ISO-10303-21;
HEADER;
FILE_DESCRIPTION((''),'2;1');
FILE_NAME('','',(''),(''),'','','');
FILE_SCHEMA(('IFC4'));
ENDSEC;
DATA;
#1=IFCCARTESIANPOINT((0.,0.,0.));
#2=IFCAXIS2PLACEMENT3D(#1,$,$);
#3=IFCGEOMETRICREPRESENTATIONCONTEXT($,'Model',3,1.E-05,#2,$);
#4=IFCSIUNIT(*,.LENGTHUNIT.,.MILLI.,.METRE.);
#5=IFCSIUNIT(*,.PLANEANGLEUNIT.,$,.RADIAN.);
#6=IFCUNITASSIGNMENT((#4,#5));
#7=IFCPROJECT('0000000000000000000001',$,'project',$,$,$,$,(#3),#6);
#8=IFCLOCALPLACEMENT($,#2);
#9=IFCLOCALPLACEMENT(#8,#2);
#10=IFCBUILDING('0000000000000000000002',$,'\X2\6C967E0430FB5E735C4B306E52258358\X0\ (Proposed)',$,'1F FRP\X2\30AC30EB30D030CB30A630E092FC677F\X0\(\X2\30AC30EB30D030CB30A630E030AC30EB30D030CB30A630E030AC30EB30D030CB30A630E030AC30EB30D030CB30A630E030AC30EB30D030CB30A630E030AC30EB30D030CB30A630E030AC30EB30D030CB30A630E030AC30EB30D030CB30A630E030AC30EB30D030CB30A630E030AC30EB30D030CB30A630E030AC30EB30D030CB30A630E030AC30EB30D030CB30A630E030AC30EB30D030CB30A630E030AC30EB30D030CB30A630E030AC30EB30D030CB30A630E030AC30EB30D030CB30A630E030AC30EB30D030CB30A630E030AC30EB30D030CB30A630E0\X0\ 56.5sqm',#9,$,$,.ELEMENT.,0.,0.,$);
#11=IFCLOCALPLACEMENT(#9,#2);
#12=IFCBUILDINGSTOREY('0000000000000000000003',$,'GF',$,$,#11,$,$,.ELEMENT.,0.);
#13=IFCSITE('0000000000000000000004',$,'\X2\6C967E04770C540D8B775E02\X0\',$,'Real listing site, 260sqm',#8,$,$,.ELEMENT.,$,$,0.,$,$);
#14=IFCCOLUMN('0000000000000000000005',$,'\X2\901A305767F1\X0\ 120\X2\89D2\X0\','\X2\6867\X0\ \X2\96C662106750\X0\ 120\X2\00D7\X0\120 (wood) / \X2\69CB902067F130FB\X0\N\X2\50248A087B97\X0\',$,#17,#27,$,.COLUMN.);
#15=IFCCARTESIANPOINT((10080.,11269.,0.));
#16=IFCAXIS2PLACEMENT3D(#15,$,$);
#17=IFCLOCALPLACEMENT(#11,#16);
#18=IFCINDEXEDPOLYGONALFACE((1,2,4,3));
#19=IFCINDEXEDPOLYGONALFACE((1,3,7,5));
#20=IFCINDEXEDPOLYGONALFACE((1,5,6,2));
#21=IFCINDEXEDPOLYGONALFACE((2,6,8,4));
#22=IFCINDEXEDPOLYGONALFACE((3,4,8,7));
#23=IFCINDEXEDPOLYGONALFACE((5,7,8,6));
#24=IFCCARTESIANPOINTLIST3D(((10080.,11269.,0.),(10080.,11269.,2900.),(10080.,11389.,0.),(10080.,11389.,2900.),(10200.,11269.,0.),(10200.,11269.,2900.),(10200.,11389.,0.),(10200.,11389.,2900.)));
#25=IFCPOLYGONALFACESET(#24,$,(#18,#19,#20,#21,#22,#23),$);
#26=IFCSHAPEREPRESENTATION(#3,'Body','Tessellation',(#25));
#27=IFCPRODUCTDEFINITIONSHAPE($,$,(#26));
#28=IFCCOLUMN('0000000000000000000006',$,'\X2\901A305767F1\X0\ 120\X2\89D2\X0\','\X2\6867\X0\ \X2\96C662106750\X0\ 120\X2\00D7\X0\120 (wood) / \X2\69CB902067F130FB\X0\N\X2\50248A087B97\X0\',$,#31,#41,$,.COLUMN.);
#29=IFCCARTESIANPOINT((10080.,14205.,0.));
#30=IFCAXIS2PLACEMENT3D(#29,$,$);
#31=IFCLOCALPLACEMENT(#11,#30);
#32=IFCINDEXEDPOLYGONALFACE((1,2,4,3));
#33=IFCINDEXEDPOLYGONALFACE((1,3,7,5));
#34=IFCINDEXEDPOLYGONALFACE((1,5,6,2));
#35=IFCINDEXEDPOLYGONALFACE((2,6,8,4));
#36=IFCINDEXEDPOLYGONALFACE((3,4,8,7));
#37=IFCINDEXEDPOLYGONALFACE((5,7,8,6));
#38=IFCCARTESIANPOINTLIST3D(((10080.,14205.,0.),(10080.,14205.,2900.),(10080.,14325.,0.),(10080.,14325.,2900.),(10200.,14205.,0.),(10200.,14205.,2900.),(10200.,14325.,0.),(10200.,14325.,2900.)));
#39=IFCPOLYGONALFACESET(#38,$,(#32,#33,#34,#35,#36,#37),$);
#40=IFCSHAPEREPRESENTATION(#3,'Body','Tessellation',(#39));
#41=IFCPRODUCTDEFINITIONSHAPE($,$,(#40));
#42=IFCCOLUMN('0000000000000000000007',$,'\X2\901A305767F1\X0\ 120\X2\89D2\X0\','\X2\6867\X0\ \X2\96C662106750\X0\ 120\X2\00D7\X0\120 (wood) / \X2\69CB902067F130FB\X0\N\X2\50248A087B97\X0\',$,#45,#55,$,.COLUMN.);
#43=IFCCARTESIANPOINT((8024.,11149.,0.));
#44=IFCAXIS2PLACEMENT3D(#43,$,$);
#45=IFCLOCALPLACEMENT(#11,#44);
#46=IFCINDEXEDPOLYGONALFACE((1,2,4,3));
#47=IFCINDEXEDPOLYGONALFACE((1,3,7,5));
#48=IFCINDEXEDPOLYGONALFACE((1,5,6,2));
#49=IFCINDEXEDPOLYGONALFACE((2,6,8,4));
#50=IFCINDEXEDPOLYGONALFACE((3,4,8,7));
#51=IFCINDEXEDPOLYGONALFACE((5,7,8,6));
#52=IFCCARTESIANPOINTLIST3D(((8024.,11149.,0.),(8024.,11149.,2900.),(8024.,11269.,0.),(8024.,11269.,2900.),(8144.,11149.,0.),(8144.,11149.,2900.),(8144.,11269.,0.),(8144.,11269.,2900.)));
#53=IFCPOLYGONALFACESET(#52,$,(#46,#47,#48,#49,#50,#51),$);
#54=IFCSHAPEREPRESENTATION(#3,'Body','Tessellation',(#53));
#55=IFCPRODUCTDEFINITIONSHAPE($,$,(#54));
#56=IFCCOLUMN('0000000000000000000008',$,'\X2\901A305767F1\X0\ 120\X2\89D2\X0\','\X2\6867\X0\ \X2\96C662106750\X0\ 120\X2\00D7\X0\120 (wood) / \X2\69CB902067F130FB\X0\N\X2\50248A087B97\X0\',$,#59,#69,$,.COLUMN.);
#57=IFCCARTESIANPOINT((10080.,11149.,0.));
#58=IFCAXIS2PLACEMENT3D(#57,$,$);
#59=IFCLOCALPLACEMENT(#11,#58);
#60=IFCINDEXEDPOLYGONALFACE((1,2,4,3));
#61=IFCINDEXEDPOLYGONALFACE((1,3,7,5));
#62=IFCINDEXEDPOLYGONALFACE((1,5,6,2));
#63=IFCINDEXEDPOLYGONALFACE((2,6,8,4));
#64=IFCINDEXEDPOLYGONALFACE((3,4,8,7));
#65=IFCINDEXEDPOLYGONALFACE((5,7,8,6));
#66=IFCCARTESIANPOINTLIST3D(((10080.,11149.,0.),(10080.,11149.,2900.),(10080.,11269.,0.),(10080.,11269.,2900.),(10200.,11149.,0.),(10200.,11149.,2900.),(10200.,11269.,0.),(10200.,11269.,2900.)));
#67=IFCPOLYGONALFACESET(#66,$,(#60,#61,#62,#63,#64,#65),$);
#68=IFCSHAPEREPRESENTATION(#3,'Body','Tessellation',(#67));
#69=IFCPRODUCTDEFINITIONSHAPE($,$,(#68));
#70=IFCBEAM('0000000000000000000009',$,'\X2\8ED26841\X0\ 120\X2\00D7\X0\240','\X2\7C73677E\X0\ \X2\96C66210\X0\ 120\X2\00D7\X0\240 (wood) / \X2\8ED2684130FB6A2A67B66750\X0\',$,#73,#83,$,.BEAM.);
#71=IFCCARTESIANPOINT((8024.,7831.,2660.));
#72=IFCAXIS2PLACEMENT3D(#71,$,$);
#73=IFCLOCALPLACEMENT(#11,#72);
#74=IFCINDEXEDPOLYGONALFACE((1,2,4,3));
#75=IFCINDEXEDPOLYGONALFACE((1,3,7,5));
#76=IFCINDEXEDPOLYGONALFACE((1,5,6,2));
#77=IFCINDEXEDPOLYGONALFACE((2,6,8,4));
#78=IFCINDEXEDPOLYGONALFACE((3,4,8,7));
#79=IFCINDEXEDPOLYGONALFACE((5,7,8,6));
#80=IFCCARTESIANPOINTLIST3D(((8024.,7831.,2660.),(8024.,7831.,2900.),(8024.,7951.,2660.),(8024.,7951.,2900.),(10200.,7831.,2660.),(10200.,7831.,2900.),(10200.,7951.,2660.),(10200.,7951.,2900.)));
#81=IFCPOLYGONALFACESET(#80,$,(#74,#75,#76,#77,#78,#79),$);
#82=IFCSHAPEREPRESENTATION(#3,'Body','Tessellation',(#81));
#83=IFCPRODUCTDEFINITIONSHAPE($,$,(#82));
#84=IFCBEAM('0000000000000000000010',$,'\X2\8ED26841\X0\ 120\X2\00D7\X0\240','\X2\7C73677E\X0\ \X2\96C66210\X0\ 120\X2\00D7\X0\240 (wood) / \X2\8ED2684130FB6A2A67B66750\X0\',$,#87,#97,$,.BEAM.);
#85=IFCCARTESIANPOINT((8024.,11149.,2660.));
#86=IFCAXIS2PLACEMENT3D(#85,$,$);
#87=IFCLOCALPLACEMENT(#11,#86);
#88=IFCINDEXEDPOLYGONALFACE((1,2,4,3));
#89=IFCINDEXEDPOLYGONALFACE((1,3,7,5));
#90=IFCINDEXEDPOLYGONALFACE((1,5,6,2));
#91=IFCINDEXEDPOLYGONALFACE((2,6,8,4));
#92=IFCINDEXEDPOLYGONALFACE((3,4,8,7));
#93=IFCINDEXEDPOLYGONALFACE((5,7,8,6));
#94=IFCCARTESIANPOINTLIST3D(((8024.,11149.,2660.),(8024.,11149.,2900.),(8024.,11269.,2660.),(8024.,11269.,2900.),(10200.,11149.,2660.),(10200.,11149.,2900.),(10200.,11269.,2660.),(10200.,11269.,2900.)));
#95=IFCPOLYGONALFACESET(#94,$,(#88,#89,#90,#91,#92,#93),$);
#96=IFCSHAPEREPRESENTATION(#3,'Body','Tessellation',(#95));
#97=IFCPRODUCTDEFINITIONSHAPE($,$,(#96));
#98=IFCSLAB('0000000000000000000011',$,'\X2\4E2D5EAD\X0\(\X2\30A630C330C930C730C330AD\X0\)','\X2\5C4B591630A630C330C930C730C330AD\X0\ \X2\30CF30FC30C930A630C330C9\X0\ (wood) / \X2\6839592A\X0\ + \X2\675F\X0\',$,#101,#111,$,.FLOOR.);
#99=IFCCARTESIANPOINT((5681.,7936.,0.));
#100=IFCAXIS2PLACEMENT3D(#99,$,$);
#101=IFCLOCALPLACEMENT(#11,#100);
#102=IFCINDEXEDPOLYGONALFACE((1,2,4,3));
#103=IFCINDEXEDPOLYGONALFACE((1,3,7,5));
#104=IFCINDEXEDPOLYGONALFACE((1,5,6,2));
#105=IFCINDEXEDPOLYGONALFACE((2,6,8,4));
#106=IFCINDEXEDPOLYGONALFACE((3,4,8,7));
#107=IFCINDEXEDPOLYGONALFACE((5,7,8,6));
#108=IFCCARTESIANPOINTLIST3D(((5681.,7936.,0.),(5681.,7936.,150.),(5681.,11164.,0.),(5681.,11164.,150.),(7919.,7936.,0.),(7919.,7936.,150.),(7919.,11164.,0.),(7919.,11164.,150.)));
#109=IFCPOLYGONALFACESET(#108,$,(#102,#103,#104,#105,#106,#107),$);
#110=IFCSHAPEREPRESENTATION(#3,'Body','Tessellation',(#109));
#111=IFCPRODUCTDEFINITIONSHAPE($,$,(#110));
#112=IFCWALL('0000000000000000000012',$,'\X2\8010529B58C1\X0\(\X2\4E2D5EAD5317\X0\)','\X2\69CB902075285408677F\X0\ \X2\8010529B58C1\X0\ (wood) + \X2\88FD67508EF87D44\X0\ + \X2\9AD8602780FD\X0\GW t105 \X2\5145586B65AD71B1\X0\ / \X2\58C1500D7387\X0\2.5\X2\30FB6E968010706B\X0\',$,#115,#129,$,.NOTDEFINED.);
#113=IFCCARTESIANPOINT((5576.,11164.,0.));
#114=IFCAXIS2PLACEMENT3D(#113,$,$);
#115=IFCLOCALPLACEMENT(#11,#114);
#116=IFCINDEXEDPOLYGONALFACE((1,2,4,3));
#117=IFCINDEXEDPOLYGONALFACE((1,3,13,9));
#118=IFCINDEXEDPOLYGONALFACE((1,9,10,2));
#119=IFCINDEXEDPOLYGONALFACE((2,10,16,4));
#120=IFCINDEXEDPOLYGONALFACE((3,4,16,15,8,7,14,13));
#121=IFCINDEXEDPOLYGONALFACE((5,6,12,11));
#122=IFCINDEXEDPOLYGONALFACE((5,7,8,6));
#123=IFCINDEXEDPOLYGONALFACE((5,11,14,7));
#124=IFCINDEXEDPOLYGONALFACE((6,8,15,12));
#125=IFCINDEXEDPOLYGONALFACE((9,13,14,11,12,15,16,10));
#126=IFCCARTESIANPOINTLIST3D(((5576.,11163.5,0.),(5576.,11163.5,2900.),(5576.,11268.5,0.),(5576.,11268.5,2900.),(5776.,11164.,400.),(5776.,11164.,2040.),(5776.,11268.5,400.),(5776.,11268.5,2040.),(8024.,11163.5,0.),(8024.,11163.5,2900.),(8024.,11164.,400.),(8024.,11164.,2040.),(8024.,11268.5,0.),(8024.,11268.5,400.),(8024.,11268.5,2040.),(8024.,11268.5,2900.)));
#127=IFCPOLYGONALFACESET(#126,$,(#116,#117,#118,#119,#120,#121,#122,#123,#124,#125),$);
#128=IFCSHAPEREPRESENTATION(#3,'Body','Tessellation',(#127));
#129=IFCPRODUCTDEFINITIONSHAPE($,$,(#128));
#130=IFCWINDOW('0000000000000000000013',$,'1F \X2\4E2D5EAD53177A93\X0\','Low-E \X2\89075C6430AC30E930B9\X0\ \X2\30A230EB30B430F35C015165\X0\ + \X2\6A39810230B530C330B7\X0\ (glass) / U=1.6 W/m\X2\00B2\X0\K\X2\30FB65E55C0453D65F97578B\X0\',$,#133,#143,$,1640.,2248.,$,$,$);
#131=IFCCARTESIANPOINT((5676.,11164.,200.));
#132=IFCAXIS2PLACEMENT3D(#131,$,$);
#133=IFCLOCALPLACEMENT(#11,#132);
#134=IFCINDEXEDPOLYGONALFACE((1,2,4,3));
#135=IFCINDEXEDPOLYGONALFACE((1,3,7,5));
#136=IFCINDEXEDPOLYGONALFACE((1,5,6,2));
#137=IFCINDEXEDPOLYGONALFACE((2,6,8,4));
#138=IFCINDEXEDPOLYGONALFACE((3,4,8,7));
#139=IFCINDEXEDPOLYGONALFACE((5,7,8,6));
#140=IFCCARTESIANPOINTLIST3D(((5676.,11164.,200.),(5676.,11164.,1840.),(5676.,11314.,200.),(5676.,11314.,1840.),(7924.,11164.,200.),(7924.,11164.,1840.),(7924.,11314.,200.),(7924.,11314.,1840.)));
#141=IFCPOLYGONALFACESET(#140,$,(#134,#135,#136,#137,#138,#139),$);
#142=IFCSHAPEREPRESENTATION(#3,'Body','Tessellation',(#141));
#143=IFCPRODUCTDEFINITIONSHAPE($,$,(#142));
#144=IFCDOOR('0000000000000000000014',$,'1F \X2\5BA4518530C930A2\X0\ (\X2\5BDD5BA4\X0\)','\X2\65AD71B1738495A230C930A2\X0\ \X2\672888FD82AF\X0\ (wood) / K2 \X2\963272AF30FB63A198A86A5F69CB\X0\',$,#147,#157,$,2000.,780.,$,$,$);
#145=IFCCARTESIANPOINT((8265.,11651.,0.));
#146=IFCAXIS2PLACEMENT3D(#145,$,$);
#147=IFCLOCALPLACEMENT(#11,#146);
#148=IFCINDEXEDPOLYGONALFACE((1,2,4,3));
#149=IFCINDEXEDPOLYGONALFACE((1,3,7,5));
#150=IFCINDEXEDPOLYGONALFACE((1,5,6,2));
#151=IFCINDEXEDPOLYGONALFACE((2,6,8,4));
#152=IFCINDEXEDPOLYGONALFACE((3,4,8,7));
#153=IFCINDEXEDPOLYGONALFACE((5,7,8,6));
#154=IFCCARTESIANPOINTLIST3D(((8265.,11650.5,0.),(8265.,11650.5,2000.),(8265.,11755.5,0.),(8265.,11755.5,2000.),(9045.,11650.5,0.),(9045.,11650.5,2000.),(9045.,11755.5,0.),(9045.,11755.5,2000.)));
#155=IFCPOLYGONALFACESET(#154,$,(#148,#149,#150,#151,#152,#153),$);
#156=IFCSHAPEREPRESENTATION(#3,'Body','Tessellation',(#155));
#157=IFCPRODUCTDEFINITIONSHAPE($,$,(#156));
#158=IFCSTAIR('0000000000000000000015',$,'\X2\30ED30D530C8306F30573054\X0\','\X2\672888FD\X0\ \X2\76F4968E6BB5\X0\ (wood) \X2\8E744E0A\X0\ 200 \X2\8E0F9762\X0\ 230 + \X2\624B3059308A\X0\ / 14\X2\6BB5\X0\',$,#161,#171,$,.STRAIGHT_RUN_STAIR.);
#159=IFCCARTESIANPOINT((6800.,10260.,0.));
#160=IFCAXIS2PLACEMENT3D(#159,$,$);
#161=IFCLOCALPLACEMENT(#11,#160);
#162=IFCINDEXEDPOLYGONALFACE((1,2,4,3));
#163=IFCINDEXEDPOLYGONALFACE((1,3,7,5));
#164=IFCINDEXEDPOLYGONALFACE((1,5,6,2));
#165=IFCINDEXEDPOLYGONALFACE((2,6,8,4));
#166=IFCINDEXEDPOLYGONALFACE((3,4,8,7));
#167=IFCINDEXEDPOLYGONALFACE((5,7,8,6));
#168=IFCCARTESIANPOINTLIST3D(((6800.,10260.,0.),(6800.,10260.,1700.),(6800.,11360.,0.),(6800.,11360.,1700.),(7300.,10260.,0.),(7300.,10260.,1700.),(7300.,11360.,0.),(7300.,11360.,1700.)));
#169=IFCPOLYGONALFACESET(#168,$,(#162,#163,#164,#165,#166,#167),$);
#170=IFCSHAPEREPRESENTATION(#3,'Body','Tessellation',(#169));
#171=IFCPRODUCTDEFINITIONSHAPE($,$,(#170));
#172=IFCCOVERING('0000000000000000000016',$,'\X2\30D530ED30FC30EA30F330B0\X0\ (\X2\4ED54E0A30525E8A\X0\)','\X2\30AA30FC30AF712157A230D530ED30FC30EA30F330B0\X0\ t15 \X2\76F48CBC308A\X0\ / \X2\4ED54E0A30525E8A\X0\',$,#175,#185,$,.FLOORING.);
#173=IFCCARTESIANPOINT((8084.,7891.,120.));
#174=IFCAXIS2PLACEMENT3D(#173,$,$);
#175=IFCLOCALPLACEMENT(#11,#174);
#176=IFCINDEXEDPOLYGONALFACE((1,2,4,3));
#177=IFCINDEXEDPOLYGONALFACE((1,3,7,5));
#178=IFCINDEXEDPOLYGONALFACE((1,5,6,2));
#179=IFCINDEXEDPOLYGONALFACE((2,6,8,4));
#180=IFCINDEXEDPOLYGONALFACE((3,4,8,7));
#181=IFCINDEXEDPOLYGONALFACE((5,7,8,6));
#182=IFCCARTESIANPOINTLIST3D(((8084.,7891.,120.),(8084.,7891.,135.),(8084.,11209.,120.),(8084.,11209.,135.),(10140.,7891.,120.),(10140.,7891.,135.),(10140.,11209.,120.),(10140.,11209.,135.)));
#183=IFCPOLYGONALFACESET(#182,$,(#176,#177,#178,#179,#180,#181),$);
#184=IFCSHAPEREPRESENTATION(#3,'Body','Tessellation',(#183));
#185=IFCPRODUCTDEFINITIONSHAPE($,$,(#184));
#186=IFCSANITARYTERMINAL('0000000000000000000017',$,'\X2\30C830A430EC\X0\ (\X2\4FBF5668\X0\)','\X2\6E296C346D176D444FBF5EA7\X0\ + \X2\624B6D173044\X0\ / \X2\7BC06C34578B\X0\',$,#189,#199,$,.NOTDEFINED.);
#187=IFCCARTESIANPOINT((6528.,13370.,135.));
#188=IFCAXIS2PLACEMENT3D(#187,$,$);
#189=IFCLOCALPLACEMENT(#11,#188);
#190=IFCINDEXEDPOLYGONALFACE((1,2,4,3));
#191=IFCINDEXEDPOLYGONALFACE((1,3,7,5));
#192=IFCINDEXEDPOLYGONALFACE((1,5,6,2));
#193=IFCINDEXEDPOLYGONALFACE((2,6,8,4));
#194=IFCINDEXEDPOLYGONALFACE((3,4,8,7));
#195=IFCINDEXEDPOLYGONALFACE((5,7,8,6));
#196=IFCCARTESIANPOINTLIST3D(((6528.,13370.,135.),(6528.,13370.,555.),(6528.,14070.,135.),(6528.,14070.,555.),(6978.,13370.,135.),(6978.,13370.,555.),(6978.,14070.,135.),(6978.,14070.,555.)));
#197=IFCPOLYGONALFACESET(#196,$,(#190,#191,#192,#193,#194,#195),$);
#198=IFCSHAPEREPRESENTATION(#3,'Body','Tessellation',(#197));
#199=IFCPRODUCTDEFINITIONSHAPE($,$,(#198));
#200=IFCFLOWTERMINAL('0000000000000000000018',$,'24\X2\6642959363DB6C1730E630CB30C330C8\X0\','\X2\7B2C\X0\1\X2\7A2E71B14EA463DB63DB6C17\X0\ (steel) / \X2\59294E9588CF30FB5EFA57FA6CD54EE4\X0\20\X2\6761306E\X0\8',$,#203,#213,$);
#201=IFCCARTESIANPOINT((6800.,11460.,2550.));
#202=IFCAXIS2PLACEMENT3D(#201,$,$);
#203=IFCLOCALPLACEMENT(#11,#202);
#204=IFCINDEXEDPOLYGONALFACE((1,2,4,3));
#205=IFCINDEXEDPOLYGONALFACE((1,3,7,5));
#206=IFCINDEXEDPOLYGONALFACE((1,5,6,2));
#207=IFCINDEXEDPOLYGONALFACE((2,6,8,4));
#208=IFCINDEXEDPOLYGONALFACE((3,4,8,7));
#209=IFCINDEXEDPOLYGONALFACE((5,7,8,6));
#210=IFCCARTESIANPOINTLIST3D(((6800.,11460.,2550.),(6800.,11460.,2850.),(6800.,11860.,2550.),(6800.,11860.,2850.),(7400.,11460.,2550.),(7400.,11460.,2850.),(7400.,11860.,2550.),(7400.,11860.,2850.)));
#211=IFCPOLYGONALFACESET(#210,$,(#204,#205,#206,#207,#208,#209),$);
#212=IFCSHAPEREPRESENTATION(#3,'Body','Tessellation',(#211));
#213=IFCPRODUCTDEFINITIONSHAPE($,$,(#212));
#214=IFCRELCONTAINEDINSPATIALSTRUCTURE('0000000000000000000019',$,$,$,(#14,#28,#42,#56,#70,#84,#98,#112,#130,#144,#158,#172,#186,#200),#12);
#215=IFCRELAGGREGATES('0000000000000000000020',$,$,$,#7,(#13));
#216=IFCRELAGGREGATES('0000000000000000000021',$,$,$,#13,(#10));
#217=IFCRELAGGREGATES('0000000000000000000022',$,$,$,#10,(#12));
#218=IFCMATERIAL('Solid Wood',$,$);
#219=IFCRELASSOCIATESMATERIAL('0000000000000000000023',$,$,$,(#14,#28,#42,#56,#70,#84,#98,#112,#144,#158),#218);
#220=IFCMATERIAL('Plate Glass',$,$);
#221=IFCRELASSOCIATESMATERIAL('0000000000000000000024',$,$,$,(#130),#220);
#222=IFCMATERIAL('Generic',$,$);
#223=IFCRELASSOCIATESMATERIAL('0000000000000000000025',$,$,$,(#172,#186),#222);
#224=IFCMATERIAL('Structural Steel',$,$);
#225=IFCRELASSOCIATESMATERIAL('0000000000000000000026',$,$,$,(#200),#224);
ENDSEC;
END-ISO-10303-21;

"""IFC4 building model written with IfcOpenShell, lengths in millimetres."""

from ifc_helpers import new_model, si_unit, frame, frame_2d, origin, place, context, project, spatial, rectangle, extrude, material, element, fill, save


model = new_model("IFC4")

# Units and contexts
model_context = context("Model", 3, precision=1e-05, world=origin())
ifc_project = project(units=[si_unit("LENGTHUNIT", "METRE", prefix="MILLI"), si_unit("PLANEANGLEUNIT", "RADIAN")], contexts=[model_context])

# Site, building, storey
site_placement = place(None, origin())
site = spatial("IfcSite", under=ifc_project, at=site_placement, Name="沖縄県名護市", ObjectType="Real listing site, 260sqm", CompositionType="ELEMENT", RefElevation=0.0)
building_placement = place(site_placement, origin())
building = spatial("IfcBuilding", under=site, at=building_placement, Name="沖縄・平屋の別荘 (Proposed)", ObjectType="1F FRPガルバニウム鋼板(ガルバニウムガルバニウムガルバニウムガルバニウムガルバニウムガルバニウムガルバニウムガルバニウムガルバニウムガルバニウムガルバニウムガルバニウムガルバニウムガルバニウムガルバニウムガルバニウムガルバニウムガルバニウム 56.5sqm", CompositionType="ELEMENT", ElevationOfRefHeight=0.0, ElevationOfTerrain=0.0)
storey_placement = place(building_placement, origin())
storey = spatial("IfcBuildingStorey", under=building, at=storey_placement, Name="GF", CompositionType="ELEMENT", Elevation=0.0)

# Columns
ifc_material_1 = material(Name="Solid Wood")
column_1_placement = place(storey_placement, frame((10080.0, 11269.0, 0.0)))
element("IfcColumn", 1, at=column_1_placement, inside=storey, material=ifc_material_1, Name="通し柱 120角", Description="桧 集成材 120×120 (wood) / 構造柱・N値計算", PredefinedType="COLUMN", context=model_context, shape_type="SweptSolid", body=[
    extrude(rectangle(XDim=120.0, YDim=120.0, at=frame_2d((60.0, 60.0))), frame((10080.0, 11269.0, 0.0)), (0.0, 0.0, 1.0), 2900.0),
])
column_2_placement = place(storey_placement, frame((10080.0, 14205.0, 0.0)))
element("IfcColumn", 2, at=column_2_placement, inside=storey, material=ifc_material_1, Name="通し柱 120角", Description="桧 集成材 120×120 (wood) / 構造柱・N値計算", PredefinedType="COLUMN", context=model_context, shape_type="SweptSolid", body=[
    extrude(rectangle(XDim=120.0, YDim=120.0, at=frame_2d((60.0, 60.0))), frame((10080.0, 14205.0, 0.0)), (0.0, 0.0, 1.0), 2900.0),
])
column_3_placement = place(storey_placement, frame((8024.0, 11149.0, 0.0)))
element("IfcColumn", 3, at=column_3_placement, inside=storey, material=ifc_material_1, Name="通し柱 120角", Description="桧 集成材 120×120 (wood) / 構造柱・N値計算", PredefinedType="COLUMN", context=model_context, shape_type="SweptSolid", body=[
    extrude(rectangle(XDim=120.0, YDim=120.0, at=frame_2d((60.0, 60.0))), frame((8024.0, 11149.0, 0.0)), (0.0, 0.0, 1.0), 2900.0),
])
column_4_placement = place(storey_placement, frame((10080.0, 11149.0, 0.0)))
element("IfcColumn", 4, at=column_4_placement, inside=storey, material=ifc_material_1, Name="通し柱 120角", Description="桧 集成材 120×120 (wood) / 構造柱・N値計算", PredefinedType="COLUMN", context=model_context, shape_type="SweptSolid", body=[
    extrude(rectangle(XDim=120.0, YDim=120.0, at=frame_2d((60.0, 60.0))), frame((10080.0, 11149.0, 0.0)), (0.0, 0.0, 1.0), 2900.0),
])

# Beams
beam_1_placement = place(storey_placement, frame((8024.0, 7831.0, 2660.0)))
element("IfcBeam", 5, at=beam_1_placement, inside=storey, material=ifc_material_1, Name="軒桁 120×240", Description="米松 集成 120×240 (wood) / 軒桁・横架材", PredefinedType="BEAM", context=model_context, shape_type="SweptSolid", body=[
    extrude(rectangle(XDim=2176.0, YDim=120.0, at=frame_2d((1088.0, 60.0))), frame((8024.0, 7831.0, 2660.0)), (0.0, 0.0, 1.0), 240.0),
])
beam_2_placement = place(storey_placement, frame((8024.0, 11149.0, 2660.0)))
element("IfcBeam", 6, at=beam_2_placement, inside=storey, material=ifc_material_1, Name="軒桁 120×240", Description="米松 集成 120×240 (wood) / 軒桁・横架材", PredefinedType="BEAM", context=model_context, shape_type="SweptSolid", body=[
    extrude(rectangle(XDim=2176.0, YDim=120.0, at=frame_2d((1088.0, 60.0))), frame((8024.0, 11149.0, 2660.0)), (0.0, 0.0, 1.0), 240.0),
])

# Slab
slab_placement = place(storey_placement, frame((5681.0, 7936.0, 0.0)))
element("IfcSlab", 7, at=slab_placement, inside=storey, material=ifc_material_1, Name="中庭(ウッドデッキ)", Description="屋外ウッドデッキ ハードウッド (wood) / 根太 + 束", PredefinedType="FLOOR", context=model_context, shape_type="SweptSolid", body=[
    extrude(rectangle(XDim=2238.0, YDim=3228.0, at=frame_2d((1119.0, 1614.0))), frame((5681.0, 7936.0, 0.0)), (0.0, 0.0, 1.0), 150.0),
])

# Wall, opening, window
wall_1_placement = place(storey_placement, frame((5576.0, 11164.0, 0.0)))
wall_1 = element("IfcWall", 8, at=wall_1_placement, inside=storey, material=ifc_material_1, Name="耐力壁(中庭北)", Description="構造用合板 耐力壁 (wood) + 製材軸組 + 高性能GW t105 充填断熱 / 壁倍率2.5・準耐火", PredefinedType="NOTDEFINED", context=model_context, shape_type="SweptSolid", body=[
    extrude(rectangle(XDim=2448.0, YDim=105.0, at=frame_2d((1224.0, 52.0))), frame((5576.0, 11164.0, 0.0)), (0.0, 0.0, 1.0), 2900.0),
])
opening_placement = place(storey_placement, frame((5676.0, 11164.0, 200.0)))
opening = element("IfcOpeningElement", 9, at=opening_placement, cuts=wall_1, PredefinedType="NOTDEFINED", context=model_context, shape_type="SweptSolid", body=[
    extrude(rectangle(XDim=2248.0, YDim=150.0, at=frame_2d((1124.0, 75.0))), frame((5676.0, 11164.0, 200.0)), (0.0, 0.0, 1.0), 1640.0),
])
ifc_material_2 = material(Name="Plate Glass")
window_placement = place(storey_placement, frame((5676.0, 11164.0, 200.0)))
window = element("IfcWindow", 10, at=window_placement, inside=storey, material=ifc_material_2, Name="1F 中庭北窓", Description="Low-E 複層ガラス アルゴン封入 + 樹脂サッシ (glass) / U=1.6 W/m²K・日射取得型", OverallHeight=1640.0, OverallWidth=2248.0, context=model_context, shape_type="SweptSolid", body=[
    extrude(rectangle(XDim=2248.0, YDim=150.0, at=frame_2d((1124.0, 75.0))), frame((5676.0, 11164.0, 200.0)), (0.0, 0.0, 1.0), 1640.0),
])
fill(opening, window)

# Door
door_placement = place(storey_placement, frame((8265.0, 11651.0, 0.0)))
element("IfcDoor", 11, at=door_placement, inside=storey, material=ifc_material_1, Name="1F 室内ドア (寝室)", Description="断熱玄関ドア 木製芯 (wood) / K2 防犯・採風機構", OverallHeight=2000.0, OverallWidth=780.0, context=model_context, shape_type="SweptSolid", body=[
    extrude(rectangle(XDim=780.0, YDim=105.0, at=frame_2d((390.0, 52.0))), frame((8265.0, 11651.0, 0.0)), (0.0, 0.0, 1.0), 2000.0),
])

# Stair
stair_placement = place(storey_placement, frame((6800.0, 10260.0, 0.0)))
element("IfcStair", 12, at=stair_placement, inside=storey, material=ifc_material_1, Name="ロフトはしご", Description="木製 直階段 (wood) 蹴上 200 踏面 230 + 手すり / 14段", PredefinedType="STRAIGHT_RUN_STAIR", context=model_context, shape_type="SweptSolid", body=[
    extrude(rectangle(XDim=500.0, YDim=1100.0, at=frame_2d((250.0, 550.0))), frame((6800.0, 10260.0, 0.0)), (0.0, 0.0, 1.0), 1700.0),
])

# Covering
ifc_material_3 = material(Name="Generic")
covering_placement = place(storey_placement, frame((8084.0, 7891.0, 120.0)))
element("IfcCovering", 13, at=covering_placement, inside=storey, material=ifc_material_3, Name="フローリング (仕上げ床)", Description="オーク無垢フローリング t15 直貼り / 仕上げ床", PredefinedType="FLOORING", context=model_context, shape_type="SweptSolid", body=[
    extrude(rectangle(XDim=2056.0, YDim=3318.0, at=frame_2d((1028.0, 1659.0))), frame((8084.0, 7891.0, 120.0)), (0.0, 0.0, 1.0), 15.0),
])

# Sanitary terminal
sanitary_terminal_placement = place(storey_placement, frame((6528.0, 13370.0, 135.0)))
element("IfcSanitaryTerminal", 14, at=sanitary_terminal_placement, inside=storey, material=ifc_material_3, Name="トイレ (便器)", Description="温水洗浄便座 + 手洗い / 節水型", PredefinedType="NOTDEFINED", context=model_context, shape_type="SweptSolid", body=[
    extrude(rectangle(XDim=450.0, YDim=700.0, at=frame_2d((225.0, 350.0))), frame((6528.0, 13370.0, 135.0)), (0.0, 0.0, 1.0), 420.0),
])

# Flow terminal
ifc_material_4 = material(Name="Structural Steel")
flow_terminal_placement = place(storey_placement, frame((6800.0, 11460.0, 2550.0)))
element("IfcFlowTerminal", 15, at=flow_terminal_placement, inside=storey, material=ifc_material_4, Name="24時間換気ユニット", Description="第1種熱交換換気 (steel) / 天井裏・建基法令20条の8", context=model_context, shape_type="SweptSolid", body=[
    extrude(rectangle(XDim=600.0, YDim=400.0, at=frame_2d((300.0, 200.0))), frame((6800.0, 11460.0, 2550.0)), (0.0, 0.0, 1.0), 300.0),
])

save(model, "model.ifc")
